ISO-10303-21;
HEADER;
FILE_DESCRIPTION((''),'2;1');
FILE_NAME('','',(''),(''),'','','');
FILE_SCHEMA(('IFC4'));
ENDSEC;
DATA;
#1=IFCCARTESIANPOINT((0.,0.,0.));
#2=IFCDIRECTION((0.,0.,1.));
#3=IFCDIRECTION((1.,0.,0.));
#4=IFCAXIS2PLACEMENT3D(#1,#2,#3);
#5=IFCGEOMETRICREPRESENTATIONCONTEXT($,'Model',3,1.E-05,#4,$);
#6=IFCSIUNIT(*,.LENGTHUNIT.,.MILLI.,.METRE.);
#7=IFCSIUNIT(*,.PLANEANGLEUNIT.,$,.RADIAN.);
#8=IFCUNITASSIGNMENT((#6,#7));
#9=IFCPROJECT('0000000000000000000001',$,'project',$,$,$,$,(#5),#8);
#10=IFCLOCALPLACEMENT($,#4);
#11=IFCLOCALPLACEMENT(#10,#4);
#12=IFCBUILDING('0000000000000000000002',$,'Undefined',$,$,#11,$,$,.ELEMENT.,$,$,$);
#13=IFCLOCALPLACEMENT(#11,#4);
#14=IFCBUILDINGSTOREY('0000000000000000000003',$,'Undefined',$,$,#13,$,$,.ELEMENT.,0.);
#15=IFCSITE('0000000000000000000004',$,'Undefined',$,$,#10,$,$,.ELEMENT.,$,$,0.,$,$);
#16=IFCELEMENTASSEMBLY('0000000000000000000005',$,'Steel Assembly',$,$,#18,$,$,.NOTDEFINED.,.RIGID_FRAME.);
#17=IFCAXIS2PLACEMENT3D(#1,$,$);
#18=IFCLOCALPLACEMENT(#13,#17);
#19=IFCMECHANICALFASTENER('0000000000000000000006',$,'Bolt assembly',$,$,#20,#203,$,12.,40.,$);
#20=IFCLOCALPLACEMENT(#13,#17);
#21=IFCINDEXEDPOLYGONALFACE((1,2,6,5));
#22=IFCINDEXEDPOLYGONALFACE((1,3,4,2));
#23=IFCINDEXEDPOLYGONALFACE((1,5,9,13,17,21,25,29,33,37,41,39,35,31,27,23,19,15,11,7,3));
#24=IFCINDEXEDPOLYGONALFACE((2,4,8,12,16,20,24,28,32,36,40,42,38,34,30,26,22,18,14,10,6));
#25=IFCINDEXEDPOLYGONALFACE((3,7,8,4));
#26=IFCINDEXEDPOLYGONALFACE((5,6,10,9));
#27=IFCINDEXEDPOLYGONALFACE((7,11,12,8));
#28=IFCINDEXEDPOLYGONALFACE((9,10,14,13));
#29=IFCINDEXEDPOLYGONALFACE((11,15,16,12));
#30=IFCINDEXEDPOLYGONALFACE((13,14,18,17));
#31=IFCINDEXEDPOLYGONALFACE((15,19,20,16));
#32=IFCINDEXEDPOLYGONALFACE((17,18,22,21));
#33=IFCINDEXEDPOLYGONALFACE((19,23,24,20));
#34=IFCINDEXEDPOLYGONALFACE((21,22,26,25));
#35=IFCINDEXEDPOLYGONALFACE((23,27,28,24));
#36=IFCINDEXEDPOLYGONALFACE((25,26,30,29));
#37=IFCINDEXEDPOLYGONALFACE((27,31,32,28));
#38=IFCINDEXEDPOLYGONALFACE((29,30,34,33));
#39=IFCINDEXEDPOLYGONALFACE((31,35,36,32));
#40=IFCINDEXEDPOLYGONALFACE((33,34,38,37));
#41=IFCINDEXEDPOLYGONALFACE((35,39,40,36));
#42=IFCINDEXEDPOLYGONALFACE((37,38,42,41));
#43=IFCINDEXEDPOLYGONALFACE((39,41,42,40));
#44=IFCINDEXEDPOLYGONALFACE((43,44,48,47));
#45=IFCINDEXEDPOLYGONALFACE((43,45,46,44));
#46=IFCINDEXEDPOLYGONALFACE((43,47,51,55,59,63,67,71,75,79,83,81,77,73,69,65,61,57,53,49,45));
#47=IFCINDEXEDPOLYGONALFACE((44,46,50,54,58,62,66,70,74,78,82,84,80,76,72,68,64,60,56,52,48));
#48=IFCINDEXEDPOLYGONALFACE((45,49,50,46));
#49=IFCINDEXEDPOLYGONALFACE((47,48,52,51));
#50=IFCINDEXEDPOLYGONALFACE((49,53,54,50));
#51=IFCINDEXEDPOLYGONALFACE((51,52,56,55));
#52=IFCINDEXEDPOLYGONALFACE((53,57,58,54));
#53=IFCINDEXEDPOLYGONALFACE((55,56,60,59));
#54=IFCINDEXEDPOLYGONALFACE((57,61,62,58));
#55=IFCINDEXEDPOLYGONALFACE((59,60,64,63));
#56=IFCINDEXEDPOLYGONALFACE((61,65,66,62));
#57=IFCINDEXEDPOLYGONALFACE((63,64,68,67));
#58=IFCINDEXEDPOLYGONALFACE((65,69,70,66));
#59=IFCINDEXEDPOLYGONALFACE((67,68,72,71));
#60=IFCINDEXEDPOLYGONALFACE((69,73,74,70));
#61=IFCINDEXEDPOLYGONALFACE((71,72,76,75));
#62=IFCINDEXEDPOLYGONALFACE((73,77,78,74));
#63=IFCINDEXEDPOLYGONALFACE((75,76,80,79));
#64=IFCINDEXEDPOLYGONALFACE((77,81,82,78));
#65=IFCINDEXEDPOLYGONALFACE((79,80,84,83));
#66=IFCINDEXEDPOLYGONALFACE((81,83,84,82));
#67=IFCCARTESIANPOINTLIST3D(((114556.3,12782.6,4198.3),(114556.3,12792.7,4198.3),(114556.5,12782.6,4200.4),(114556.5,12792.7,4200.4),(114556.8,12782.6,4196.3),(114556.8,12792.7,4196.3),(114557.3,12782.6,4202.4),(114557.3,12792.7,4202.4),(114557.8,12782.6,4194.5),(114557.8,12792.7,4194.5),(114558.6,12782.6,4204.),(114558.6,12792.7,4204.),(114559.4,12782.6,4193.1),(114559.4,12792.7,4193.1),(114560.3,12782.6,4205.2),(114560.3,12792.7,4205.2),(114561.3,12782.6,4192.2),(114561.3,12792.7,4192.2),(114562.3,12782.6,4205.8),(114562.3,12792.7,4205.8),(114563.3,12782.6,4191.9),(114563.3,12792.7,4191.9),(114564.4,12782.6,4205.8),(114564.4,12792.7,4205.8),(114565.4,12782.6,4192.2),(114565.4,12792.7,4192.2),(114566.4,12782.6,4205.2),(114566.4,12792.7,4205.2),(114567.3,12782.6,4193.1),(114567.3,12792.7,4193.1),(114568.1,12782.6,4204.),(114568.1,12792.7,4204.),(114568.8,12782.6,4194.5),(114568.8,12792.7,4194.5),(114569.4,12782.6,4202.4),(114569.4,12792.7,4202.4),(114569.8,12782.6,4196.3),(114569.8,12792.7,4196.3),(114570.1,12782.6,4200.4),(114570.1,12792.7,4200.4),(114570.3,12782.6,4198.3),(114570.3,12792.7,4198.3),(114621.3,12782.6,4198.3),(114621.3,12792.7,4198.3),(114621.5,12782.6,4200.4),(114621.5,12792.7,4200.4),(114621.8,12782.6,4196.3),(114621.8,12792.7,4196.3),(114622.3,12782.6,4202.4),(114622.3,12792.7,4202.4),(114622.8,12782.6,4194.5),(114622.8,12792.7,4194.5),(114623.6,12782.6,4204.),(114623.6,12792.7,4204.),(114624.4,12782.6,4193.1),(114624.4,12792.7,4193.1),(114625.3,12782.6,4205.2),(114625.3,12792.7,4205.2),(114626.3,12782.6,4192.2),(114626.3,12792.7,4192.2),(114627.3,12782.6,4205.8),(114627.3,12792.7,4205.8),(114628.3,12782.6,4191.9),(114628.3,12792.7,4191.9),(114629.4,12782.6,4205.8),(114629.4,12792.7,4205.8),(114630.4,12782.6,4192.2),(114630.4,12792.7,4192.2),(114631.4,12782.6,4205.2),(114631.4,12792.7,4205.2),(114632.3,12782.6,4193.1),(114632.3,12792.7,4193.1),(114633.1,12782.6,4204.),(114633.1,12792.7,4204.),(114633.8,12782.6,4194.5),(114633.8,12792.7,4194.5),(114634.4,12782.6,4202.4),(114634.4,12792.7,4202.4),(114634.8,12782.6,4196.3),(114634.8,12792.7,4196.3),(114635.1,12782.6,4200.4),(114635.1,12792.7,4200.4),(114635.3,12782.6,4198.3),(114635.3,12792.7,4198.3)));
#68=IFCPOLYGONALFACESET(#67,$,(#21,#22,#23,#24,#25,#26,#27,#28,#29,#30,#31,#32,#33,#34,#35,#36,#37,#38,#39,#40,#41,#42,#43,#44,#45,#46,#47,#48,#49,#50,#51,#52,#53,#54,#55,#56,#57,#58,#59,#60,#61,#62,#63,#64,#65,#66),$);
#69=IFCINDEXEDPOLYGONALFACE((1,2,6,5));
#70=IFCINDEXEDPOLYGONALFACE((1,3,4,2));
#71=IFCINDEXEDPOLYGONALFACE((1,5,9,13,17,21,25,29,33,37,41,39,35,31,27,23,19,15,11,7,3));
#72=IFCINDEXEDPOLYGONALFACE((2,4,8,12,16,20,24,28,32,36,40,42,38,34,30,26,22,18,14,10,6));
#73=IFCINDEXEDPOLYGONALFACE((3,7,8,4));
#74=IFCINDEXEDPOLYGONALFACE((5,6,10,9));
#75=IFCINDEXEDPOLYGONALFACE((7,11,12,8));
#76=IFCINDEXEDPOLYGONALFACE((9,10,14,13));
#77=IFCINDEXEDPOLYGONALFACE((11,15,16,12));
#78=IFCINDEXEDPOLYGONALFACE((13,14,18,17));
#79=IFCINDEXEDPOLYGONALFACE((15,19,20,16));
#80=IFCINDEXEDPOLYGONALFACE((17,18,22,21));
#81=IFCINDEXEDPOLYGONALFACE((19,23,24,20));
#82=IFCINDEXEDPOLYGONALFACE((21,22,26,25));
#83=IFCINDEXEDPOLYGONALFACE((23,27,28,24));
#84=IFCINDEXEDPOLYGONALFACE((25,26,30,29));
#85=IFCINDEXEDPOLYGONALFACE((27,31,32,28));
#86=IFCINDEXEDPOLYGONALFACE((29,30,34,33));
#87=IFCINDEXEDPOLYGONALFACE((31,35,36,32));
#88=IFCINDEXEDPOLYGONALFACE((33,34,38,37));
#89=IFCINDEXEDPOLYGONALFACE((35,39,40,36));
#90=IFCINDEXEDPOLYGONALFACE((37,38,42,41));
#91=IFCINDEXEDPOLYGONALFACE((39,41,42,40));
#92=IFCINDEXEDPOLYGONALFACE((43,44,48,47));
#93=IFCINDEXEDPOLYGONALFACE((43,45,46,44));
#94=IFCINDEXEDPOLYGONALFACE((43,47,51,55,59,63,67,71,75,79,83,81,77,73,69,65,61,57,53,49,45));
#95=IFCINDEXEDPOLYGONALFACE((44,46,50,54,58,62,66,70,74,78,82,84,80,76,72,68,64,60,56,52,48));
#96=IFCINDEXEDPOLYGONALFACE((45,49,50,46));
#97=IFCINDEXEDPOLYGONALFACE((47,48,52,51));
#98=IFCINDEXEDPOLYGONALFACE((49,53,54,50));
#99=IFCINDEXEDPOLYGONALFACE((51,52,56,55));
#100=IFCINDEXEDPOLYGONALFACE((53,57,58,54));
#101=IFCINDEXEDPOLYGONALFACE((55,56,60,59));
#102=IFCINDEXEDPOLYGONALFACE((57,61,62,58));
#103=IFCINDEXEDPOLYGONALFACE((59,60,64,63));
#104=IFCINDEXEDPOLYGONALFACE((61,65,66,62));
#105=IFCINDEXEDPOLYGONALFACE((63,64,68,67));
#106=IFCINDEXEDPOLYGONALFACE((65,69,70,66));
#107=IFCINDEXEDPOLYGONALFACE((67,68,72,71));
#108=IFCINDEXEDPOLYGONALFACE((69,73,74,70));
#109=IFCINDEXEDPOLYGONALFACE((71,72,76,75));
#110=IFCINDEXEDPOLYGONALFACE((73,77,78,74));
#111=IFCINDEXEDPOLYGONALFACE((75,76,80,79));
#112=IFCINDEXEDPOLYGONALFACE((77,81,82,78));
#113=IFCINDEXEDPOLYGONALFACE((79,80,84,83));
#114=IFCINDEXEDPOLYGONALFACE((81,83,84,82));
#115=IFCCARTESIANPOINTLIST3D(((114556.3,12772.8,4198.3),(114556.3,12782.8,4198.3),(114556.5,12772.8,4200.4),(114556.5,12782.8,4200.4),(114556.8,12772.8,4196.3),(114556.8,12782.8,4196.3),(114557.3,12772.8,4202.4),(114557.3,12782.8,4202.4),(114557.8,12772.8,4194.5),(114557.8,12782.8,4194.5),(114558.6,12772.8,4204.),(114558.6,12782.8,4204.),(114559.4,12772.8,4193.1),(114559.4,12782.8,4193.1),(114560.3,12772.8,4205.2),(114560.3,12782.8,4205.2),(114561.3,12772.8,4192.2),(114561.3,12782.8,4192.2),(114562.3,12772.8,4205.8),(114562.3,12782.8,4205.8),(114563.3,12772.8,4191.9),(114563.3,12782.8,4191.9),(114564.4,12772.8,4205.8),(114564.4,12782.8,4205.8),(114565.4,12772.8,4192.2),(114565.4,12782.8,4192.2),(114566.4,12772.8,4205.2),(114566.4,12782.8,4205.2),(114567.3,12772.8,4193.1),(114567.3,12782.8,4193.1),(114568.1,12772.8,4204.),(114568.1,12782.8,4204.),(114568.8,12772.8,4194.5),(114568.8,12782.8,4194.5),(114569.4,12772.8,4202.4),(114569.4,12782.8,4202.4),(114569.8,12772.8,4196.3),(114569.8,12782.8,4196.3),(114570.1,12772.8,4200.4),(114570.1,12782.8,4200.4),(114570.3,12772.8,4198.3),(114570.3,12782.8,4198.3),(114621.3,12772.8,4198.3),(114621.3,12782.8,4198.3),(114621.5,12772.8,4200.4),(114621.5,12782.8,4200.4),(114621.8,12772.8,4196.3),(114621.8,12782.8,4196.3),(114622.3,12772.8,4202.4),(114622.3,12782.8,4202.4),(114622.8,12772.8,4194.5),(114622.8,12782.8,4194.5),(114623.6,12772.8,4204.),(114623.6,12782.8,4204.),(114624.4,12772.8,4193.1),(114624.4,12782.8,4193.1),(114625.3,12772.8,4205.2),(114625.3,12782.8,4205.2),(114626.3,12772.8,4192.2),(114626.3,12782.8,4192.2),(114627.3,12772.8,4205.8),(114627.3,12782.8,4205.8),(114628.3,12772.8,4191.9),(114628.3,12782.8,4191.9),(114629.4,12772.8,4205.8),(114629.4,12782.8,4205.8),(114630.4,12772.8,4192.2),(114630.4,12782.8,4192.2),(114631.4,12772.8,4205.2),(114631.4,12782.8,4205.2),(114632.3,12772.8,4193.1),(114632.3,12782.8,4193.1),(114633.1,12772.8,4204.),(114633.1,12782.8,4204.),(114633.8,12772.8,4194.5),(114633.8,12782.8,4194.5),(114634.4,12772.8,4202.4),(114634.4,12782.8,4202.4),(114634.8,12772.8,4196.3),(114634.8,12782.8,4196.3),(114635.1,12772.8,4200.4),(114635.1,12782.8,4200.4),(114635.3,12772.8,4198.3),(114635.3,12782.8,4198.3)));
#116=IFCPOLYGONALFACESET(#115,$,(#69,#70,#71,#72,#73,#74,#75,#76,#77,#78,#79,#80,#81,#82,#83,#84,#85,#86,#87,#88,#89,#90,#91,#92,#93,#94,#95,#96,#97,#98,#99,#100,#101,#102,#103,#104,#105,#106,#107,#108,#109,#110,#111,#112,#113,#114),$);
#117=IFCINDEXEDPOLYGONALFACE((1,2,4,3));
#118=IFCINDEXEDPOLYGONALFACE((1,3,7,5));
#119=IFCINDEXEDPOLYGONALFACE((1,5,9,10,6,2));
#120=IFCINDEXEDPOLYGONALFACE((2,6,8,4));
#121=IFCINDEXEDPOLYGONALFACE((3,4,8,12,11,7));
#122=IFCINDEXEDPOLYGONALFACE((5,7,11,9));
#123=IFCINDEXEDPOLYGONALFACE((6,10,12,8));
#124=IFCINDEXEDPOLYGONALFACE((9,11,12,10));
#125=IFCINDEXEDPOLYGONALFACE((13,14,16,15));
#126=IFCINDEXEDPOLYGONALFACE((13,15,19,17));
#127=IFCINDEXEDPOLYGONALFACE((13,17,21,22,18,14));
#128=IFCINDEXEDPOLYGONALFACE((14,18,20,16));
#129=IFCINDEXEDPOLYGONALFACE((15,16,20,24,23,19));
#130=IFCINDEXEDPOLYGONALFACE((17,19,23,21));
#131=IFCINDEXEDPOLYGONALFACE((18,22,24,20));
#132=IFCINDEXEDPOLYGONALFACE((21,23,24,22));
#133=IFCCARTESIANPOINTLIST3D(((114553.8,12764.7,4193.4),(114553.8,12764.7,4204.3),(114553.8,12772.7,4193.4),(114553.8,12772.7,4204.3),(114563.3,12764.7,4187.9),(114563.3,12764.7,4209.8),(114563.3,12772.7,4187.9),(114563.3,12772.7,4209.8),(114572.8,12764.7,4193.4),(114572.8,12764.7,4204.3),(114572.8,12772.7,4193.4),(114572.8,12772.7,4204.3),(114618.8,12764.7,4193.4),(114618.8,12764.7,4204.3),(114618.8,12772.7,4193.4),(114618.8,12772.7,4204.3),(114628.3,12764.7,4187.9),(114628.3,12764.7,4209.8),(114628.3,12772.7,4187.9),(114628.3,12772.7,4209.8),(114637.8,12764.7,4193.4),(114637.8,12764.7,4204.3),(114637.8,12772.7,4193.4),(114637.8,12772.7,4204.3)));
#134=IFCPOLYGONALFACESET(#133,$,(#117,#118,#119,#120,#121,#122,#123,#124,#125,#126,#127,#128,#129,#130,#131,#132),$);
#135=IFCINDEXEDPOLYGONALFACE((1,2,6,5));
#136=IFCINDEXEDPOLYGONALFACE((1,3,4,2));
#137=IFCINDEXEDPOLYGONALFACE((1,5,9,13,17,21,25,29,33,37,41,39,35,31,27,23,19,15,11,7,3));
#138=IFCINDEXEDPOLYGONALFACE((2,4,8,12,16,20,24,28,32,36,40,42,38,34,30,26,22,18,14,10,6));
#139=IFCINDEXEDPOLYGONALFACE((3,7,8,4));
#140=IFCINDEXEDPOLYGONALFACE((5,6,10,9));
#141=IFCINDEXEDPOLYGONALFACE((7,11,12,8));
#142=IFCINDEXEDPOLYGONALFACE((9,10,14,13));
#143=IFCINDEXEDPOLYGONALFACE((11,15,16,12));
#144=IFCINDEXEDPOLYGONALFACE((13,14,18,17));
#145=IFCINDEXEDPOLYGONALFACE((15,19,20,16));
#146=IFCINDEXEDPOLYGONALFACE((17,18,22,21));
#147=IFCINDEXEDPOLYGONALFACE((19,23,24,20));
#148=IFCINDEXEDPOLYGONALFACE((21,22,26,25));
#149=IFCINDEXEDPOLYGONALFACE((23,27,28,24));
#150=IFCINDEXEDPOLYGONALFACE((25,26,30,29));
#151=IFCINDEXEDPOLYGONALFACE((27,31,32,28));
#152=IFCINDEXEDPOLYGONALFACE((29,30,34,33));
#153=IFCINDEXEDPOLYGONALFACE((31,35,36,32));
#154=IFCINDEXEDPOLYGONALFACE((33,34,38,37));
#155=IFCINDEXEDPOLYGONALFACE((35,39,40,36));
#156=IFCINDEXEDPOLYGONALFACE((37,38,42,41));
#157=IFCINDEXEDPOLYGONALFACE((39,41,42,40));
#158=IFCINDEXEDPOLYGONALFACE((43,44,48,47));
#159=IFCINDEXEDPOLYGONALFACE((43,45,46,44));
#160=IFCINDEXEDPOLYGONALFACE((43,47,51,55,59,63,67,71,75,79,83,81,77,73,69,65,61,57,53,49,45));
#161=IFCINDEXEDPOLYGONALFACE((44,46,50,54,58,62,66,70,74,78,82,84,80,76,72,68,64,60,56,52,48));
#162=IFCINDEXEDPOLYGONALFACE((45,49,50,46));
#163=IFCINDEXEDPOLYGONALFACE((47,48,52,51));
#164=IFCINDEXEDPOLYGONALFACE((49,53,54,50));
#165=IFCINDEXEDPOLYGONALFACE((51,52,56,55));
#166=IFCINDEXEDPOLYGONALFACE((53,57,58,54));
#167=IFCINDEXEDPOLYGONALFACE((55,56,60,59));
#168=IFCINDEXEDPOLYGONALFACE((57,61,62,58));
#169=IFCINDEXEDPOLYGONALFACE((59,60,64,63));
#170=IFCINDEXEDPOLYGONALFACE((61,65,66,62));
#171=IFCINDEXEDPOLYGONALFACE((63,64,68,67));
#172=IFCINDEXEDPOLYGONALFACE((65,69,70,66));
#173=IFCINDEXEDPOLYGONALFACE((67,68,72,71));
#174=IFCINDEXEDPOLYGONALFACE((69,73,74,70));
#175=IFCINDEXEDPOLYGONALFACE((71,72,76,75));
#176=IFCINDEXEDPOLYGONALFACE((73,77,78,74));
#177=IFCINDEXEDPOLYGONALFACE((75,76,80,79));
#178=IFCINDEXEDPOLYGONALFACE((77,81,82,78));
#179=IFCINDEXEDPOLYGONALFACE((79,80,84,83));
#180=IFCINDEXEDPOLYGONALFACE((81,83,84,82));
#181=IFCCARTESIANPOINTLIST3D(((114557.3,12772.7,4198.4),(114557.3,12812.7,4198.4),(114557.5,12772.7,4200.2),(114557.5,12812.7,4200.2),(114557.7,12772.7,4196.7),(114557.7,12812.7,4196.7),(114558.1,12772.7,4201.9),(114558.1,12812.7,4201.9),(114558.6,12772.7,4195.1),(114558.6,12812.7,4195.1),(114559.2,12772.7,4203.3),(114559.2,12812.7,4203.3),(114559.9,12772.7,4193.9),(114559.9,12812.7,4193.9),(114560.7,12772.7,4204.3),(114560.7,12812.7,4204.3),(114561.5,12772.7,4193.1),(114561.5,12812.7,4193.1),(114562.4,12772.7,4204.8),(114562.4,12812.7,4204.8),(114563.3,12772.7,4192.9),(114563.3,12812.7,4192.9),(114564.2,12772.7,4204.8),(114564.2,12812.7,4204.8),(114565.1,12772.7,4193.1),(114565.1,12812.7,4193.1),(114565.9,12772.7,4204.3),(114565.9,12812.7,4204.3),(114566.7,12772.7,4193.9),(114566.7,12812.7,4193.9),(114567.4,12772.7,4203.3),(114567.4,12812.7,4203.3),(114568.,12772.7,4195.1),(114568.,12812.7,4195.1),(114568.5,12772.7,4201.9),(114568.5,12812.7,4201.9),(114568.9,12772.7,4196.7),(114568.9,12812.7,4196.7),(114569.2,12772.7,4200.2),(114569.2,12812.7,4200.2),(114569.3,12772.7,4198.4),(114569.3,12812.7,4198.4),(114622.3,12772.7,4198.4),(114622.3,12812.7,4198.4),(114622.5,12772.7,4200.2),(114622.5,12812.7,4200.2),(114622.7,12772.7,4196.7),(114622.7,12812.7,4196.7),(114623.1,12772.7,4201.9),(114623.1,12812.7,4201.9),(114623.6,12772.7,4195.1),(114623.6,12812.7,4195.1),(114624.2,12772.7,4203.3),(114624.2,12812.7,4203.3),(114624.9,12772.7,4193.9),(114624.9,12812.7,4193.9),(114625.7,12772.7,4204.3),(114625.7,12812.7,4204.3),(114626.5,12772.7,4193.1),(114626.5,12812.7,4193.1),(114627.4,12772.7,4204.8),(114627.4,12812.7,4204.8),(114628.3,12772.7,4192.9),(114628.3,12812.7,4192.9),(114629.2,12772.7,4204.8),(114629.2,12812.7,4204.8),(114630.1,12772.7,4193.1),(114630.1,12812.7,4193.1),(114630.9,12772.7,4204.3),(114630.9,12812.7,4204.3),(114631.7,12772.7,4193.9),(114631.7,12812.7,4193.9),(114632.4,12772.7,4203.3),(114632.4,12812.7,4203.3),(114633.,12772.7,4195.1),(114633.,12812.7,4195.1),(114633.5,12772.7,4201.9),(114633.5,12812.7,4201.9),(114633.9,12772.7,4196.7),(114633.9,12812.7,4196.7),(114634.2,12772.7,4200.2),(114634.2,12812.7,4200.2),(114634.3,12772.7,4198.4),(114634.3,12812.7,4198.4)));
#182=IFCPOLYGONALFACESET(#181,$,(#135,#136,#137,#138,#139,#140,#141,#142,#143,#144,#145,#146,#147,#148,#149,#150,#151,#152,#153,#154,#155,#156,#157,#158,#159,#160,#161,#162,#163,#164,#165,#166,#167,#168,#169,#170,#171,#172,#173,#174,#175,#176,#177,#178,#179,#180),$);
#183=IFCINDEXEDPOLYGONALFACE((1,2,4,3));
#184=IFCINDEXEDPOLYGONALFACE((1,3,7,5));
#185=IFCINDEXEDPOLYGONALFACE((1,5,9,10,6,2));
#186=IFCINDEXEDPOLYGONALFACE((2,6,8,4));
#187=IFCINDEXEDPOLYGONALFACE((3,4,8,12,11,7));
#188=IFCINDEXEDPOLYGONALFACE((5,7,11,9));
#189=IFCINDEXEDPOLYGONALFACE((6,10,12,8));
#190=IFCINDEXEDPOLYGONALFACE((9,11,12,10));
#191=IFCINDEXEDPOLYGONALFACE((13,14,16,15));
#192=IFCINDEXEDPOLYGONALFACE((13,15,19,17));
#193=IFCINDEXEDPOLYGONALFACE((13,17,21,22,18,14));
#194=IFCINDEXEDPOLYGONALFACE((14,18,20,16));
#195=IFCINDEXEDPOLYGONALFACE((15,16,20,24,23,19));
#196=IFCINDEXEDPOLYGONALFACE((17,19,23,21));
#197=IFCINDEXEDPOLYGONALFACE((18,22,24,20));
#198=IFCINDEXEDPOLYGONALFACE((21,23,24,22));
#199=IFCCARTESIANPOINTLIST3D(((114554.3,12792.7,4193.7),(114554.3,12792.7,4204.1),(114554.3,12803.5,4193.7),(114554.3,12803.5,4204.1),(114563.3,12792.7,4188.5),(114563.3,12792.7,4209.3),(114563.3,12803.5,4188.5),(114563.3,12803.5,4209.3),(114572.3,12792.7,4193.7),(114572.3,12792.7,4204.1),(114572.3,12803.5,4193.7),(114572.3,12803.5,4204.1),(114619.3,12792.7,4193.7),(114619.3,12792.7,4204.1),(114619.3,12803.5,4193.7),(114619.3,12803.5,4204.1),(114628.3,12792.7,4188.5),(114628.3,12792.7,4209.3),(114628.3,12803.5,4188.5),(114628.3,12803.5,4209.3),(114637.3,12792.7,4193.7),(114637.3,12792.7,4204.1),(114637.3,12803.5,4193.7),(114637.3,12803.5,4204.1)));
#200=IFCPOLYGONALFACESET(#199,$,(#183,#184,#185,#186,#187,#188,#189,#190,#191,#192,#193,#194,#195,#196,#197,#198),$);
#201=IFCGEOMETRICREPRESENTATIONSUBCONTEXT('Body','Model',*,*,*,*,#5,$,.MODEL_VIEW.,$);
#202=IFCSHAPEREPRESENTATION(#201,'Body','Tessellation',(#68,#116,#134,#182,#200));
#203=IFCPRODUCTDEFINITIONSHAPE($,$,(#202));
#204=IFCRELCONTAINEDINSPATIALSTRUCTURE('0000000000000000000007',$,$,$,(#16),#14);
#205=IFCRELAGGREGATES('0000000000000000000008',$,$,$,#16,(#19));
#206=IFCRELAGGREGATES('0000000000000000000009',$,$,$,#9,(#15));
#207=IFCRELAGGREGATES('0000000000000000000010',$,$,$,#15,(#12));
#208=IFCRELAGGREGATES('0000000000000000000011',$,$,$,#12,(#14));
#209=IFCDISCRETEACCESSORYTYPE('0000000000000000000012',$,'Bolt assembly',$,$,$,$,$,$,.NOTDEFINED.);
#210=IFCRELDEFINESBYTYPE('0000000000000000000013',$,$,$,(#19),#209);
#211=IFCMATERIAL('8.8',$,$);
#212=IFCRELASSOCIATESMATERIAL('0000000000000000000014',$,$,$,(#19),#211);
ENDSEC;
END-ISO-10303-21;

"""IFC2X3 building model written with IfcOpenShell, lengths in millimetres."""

from ifc_helpers import new_model, si_unit, frame, origin_with_axes, origin_2d_with_axis, place, context, subcontext, project, spatial, polyline, circle, outline, extrude, source, transform, mapped, material, type_object, element, aggregate, save


model = new_model("IFC2X3")

# Units and contexts
model_context = context("Model", 3, precision=1e-05, world=origin_with_axes())
body_context = subcontext(model_context, "Body", "Model", "MODEL_VIEW")
ifc_project = project(units=[si_unit("LENGTHUNIT", "METRE", prefix="MILLI"), si_unit("PLANEANGLEUNIT", "RADIAN")], contexts=[model_context])

# Site, building, storey
site_placement = place(None, origin_with_axes())
site = spatial("IfcSite", under=ifc_project, at=site_placement, Name="Undefined", CompositionType="ELEMENT", RefElevation=0.0)
building_placement = place(site_placement, origin_with_axes())
building = spatial("IfcBuilding", under=site, at=building_placement, Name="Undefined", CompositionType="ELEMENT")
storey_placement = place(building_placement, origin_with_axes())
storey = spatial("IfcBuildingStorey", under=building, at=storey_placement, Name="Undefined", CompositionType="ELEMENT", Elevation=0.0)

# Element assembly
assembly_1_placement = place(storey_placement, origin_with_axes())
assembly_1 = element("IfcElementAssembly", 1, at=assembly_1_placement, inside=storey, Name="Steel Assembly", AssemblyPlace="NOTDEFINED", PredefinedType="RIGID_FRAME")

# Shared definitions
ifc_material_1 = material(Name="8.8")
discrete_accessory_type_1 = type_object("IfcDiscreteAccessoryType", Name="Bolt assembly")

# Mechanical fastener
shared_shape_1 = source(origin_with_axes(), body_context, "Body", "SweptSolid", [
    extrude(circle(Radius=7.0, at=origin_2d_with_axis()), frame((0.0, -5.1, 0.0), z_axis=(0.0, 1.0, 0.0), x_axis=(1.0, 0.0, 0.0)), (0.0, 0.0, 1.0), 10.1),
    extrude(circle(Radius=7.0, at=origin_2d_with_axis()), frame((0.0, -14.9, 0.0), z_axis=(0.0, 1.0, 0.0), x_axis=(1.0, 0.0, 0.0)), (0.0, 0.0, 1.0), 10.0),
    extrude(outline(polyline([(11.0, 0.0), (5.5, 9.5), (-5.5, 9.5), (-11.0, 0.0), (-5.5, -9.5), (5.5, -9.5), (11.0, 0.0)])), frame((0.0, -23.0, 0.0), z_axis=(0.0, 1.0, 0.0), x_axis=(1.0, 0.0, 0.0)), (0.0, 0.0, 1.0), 8.0),
    extrude(circle(Radius=6.0, at=origin_2d_with_axis()), frame((0.0, -15.0, 0.0), z_axis=(0.0, 1.0, 0.0), x_axis=(1.0, 0.0, 0.0)), (0.0, 0.0, 1.0), 40.0),
    extrude(outline(polyline([(10.4, 0.0), (5.2, 9.0), (-5.2, 9.0), (-10.4, 0.0), (-5.2, -9.0), (5.2, -9.0), (10.4, 0.0)])), frame((0.0, 5.0, 0.0), z_axis=(0.0, 1.0, 0.0), x_axis=(1.0, 0.0, 0.0)), (0.0, 0.0, 1.0), 10.8),
])
mechanical_fastener_1_placement = place(assembly_1_placement, frame((114595.8, 12787.7, 4198.9), z_axis=(1.0, 0.0, 0.0), x_axis=(0.0, 0.0, -1.0)))
mechanical_fastener_1 = element("IfcMechanicalFastener", 2, at=mechanical_fastener_1_placement, type_object=discrete_accessory_type_1, material=ifc_material_1, Name="Bolt assembly", NominalDiameter=12.0, NominalLength=40.0, context=body_context, shape_type="MappedRepresentation", body=[
    mapped(shared_shape_1, transform((0.0, 0.0, -32.5))),
    mapped(shared_shape_1, transform((0.0, 0.0, 32.5))),
])

aggregate(assembly_1, [mechanical_fastener_1])

save(model, "model.ifc")
